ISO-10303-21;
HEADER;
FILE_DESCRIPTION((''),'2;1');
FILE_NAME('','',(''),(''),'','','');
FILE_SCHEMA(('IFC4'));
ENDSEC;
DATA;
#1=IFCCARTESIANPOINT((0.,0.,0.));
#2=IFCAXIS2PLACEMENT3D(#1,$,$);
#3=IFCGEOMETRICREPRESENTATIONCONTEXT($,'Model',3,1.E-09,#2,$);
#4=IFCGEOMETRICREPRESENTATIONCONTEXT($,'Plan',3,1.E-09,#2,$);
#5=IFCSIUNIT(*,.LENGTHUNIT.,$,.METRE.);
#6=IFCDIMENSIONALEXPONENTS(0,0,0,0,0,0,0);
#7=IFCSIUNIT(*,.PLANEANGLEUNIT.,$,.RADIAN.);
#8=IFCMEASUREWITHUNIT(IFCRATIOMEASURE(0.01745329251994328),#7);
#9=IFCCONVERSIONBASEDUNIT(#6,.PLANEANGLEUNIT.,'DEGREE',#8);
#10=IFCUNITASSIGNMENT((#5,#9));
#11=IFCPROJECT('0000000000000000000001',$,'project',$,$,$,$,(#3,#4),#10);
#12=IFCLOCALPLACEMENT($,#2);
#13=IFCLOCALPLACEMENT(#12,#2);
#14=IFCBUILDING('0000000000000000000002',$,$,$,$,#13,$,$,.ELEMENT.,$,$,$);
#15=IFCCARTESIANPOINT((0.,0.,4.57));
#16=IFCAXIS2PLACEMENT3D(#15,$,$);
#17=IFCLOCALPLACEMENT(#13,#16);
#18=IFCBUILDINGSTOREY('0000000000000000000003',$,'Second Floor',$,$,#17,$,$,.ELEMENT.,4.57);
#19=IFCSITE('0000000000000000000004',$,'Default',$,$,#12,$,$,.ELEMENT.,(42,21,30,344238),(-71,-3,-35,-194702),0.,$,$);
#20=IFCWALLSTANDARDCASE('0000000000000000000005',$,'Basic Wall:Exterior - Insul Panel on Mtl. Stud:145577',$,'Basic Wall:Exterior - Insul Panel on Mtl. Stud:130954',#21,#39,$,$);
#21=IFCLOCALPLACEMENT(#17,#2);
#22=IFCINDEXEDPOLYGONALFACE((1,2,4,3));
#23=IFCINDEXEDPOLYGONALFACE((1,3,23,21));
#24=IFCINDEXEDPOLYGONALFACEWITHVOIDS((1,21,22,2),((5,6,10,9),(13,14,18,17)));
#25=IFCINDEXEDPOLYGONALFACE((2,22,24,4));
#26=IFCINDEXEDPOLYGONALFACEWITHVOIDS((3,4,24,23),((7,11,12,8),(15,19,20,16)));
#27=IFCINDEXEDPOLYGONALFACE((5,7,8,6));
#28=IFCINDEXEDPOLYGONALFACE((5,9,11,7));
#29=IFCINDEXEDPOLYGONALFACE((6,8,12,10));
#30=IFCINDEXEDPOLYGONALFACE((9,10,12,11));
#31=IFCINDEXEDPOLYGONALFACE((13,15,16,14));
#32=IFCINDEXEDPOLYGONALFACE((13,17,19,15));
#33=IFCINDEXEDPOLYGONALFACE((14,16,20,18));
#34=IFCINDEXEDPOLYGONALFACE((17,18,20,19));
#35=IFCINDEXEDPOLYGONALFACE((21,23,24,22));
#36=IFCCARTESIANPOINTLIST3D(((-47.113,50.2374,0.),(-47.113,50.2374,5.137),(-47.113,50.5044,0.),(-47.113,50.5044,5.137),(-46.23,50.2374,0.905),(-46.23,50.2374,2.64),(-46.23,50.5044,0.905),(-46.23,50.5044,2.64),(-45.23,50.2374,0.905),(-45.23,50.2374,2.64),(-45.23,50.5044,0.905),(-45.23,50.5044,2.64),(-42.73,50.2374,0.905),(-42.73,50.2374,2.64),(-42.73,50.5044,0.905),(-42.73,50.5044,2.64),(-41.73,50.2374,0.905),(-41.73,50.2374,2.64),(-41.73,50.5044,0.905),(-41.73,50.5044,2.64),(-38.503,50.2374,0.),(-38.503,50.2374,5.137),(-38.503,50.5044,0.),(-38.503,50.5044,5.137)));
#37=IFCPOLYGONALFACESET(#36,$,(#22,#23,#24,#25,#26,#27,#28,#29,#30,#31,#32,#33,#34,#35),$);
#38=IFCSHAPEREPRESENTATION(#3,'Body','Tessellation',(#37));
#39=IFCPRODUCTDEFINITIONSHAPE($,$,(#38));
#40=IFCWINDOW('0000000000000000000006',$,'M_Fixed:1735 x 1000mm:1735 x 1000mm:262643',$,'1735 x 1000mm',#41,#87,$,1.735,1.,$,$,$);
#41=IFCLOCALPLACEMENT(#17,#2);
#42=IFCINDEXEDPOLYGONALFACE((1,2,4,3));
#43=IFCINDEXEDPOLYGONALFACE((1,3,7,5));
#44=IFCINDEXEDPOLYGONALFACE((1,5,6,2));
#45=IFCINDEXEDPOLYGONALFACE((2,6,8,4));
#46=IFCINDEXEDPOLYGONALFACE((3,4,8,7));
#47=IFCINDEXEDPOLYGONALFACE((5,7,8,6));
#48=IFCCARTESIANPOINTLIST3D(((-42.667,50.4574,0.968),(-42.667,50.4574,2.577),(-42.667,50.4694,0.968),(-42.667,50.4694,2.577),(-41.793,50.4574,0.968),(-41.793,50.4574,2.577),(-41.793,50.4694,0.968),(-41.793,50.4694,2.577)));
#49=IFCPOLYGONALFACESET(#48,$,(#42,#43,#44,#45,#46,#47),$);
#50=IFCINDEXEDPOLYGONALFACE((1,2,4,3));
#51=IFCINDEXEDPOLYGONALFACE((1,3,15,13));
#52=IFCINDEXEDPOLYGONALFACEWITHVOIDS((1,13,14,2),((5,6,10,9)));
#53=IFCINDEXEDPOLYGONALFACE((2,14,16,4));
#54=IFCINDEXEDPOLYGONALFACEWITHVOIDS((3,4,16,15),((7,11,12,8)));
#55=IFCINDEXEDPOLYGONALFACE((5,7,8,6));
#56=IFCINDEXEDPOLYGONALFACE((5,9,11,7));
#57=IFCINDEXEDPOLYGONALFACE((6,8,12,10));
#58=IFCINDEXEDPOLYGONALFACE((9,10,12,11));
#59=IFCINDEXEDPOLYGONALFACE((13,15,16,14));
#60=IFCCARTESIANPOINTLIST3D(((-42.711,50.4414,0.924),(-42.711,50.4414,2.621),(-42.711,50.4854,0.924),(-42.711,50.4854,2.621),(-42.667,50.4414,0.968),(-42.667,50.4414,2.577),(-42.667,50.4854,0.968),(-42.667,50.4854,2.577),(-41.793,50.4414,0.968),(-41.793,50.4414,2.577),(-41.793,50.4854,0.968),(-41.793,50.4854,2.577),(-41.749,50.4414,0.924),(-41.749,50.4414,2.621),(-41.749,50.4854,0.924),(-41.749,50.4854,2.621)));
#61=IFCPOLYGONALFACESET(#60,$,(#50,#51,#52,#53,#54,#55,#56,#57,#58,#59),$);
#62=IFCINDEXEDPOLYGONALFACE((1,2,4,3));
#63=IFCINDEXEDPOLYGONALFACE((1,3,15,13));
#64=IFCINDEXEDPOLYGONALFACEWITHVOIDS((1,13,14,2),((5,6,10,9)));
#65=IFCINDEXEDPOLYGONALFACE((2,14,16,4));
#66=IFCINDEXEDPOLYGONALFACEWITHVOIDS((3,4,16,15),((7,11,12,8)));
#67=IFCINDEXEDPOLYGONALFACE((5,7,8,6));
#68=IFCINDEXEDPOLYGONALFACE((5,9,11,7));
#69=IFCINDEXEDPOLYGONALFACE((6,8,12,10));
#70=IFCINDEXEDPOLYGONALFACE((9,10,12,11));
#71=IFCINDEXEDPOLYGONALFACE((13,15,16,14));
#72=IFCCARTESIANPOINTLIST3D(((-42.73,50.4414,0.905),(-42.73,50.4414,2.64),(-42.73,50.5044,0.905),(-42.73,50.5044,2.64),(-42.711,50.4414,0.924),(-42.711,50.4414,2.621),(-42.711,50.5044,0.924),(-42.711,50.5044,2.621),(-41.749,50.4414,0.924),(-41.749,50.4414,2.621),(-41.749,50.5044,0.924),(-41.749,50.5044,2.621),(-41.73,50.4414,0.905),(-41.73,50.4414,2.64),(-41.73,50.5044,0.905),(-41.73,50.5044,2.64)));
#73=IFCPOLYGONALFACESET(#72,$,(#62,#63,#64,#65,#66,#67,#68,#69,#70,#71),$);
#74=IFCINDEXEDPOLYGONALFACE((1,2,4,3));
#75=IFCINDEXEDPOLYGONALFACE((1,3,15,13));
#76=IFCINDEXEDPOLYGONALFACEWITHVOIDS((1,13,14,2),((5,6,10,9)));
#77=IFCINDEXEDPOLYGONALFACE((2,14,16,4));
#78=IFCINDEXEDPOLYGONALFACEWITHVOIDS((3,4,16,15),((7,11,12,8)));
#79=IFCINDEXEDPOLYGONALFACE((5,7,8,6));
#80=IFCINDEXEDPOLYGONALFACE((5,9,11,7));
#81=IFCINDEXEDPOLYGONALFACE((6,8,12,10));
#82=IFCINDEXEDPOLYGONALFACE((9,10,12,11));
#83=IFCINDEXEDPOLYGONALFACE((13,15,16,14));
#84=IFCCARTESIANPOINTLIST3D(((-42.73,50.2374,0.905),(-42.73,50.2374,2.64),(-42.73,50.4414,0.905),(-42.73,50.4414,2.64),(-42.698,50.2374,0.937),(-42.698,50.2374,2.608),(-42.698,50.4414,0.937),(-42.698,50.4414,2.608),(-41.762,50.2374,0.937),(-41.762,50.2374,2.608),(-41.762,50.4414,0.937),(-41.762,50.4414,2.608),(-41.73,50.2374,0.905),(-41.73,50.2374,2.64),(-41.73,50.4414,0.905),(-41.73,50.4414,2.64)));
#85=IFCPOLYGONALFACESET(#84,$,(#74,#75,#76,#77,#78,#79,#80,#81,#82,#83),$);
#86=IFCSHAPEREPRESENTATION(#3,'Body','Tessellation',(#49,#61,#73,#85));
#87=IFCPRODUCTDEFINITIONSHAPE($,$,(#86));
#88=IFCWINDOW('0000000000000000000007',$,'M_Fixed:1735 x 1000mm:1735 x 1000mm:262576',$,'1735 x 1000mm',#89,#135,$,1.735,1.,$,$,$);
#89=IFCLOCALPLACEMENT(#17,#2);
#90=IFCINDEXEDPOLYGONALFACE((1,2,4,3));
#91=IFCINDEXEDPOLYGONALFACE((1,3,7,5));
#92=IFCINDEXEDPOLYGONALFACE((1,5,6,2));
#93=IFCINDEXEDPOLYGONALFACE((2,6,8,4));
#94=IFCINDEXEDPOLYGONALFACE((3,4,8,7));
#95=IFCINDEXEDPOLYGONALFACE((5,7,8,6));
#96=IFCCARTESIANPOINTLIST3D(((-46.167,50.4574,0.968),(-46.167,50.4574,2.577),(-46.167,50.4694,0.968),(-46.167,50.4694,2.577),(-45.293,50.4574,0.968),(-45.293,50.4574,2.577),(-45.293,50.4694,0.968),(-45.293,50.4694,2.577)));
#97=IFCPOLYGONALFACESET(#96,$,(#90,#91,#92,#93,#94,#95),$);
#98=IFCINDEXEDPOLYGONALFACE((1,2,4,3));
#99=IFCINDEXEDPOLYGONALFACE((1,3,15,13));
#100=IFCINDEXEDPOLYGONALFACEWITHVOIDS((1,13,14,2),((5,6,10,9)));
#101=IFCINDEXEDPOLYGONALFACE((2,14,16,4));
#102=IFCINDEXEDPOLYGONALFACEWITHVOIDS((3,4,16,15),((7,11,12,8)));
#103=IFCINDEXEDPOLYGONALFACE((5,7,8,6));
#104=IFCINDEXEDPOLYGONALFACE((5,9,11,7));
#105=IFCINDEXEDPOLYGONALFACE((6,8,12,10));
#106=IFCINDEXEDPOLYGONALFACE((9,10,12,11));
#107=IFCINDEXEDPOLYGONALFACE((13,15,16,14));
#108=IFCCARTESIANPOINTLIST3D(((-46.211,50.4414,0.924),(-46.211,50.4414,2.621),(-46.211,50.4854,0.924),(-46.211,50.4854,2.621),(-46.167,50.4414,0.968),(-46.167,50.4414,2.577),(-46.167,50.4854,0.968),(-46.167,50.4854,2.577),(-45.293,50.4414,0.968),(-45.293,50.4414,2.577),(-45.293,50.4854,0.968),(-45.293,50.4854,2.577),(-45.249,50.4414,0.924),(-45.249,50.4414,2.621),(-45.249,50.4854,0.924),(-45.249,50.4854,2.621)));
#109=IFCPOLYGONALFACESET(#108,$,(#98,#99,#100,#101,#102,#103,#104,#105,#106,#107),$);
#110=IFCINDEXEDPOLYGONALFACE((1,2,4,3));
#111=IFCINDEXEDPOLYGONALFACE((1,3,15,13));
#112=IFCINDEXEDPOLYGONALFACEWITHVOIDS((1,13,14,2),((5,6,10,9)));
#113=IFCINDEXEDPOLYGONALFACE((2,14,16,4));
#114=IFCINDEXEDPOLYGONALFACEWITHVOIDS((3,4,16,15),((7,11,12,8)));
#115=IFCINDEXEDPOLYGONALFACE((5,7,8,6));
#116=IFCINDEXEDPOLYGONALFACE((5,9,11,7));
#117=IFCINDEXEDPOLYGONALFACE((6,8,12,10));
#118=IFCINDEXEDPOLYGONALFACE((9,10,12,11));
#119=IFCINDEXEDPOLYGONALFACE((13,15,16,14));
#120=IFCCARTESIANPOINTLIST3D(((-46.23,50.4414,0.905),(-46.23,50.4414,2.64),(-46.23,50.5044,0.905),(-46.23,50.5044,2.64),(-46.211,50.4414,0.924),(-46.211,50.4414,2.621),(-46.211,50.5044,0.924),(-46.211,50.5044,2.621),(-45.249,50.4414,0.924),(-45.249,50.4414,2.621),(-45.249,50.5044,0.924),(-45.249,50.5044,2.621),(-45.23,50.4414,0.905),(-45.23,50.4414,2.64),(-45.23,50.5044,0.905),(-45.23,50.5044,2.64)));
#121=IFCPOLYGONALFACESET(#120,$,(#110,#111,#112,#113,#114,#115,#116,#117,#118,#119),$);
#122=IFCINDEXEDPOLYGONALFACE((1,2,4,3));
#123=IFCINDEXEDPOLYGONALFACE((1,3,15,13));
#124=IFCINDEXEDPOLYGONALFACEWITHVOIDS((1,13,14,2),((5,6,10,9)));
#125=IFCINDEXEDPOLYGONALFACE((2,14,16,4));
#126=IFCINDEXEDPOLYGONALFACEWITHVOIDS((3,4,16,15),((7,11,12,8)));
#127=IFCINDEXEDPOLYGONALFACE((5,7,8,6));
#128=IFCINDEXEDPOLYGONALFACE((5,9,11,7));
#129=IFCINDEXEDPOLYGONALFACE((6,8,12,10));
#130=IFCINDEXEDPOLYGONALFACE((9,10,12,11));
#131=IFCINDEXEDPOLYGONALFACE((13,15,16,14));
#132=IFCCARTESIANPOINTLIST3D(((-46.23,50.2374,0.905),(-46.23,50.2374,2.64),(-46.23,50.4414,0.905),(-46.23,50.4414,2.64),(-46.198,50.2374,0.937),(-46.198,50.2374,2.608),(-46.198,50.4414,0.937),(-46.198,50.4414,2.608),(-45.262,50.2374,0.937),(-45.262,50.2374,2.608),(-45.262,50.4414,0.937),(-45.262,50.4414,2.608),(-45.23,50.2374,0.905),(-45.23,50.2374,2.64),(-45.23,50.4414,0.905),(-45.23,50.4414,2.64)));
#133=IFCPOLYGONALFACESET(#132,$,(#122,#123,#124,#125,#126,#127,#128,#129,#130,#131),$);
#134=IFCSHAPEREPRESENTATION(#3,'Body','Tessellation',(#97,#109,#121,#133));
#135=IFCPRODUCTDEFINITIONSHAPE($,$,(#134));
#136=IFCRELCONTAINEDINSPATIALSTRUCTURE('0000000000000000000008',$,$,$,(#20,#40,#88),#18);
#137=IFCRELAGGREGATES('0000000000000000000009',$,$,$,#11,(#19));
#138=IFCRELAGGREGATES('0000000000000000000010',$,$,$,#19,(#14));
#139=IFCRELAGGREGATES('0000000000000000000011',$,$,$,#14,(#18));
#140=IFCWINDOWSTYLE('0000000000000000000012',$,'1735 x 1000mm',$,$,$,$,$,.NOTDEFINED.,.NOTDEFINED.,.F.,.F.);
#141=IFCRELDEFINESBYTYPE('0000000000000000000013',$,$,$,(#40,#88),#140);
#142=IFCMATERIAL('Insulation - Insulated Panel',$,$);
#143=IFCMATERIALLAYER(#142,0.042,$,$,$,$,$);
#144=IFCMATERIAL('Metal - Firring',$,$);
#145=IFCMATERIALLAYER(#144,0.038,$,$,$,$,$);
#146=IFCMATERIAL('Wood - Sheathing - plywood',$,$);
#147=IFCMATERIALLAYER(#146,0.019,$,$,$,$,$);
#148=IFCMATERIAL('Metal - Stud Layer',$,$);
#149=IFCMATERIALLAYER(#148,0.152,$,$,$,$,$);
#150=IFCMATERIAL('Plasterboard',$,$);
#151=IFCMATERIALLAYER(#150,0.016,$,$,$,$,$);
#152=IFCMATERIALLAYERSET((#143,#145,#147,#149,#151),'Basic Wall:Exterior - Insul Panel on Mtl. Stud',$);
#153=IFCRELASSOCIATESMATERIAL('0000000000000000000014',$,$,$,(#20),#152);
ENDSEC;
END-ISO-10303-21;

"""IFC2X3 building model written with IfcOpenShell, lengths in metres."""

from ifc_helpers import new_model, entity, si_unit, converted_unit, frame, frame_2d, origin, origin_2d_with_axis, place, context, project, spatial, polyline, rectangle, outline, extrude, source, transform, mapped, material, layer, layer_set, layer_usage, type_object, type_shapes, element, fill, save


model = new_model("IFC2X3")

# Units and contexts
model_context = context("Model", 3, precision=1e-09, world=origin())
plan_context = context("Plan", 3, precision=1e-09, world=origin())
ifc_project = project(units=[si_unit("LENGTHUNIT", "METRE"), converted_unit("PLANEANGLEUNIT", "DEGREE", entity("IfcRatioMeasure", 0.01745329251994328), si_unit("PLANEANGLEUNIT", "RADIAN"), dimensions=[0, 0, 0, 0, 0, 0, 0])], contexts=[model_context, plan_context])

# Site, building, storey
site_placement = place(None, origin())
site = spatial("IfcSite", under=ifc_project, at=site_placement, Name="Default", CompositionType="ELEMENT", RefLatitude=(42, 21, 30, 344238), RefLongitude=(-71, -3, -35, -194702), RefElevation=0.0)
building_placement = place(site_placement, origin())
building = spatial("IfcBuilding", under=site, at=building_placement, CompositionType="ELEMENT")
storey_placement = place(building_placement, frame((0.0, 0.0, 4.57)))
storey = spatial("IfcBuildingStorey", under=building, at=storey_placement, Name="Second Floor", CompositionType="ELEMENT", Elevation=4.57)

# Shared definitions
ifc_material_1 = material(Name="Plasterboard")
ifc_material_2 = material(Name="Metal - Stud Layer")

# Wall, openings, windows
ifc_material_3 = material(Name="Insulation - Insulated Panel")
ifc_layer_1 = layer(ifc_material_3, 0.042)
ifc_material_4 = material(Name="Metal - Firring")
ifc_layer_2 = layer(ifc_material_4, 0.038)
ifc_material_5 = material(Name="Wood - Sheathing - plywood")
ifc_layer_3 = layer(ifc_material_5, 0.019)
ifc_layer_4 = layer(ifc_material_2, 0.152)
ifc_layer_5 = layer(ifc_material_1, 0.016)
ifc_layer_set_1 = layer_set([ifc_layer_1, ifc_layer_2, ifc_layer_3, ifc_layer_4, ifc_layer_5], Name="Basic Wall:Exterior - Insul Panel on Mtl. Stud")
ifc_layer_usage_1 = layer_usage(ifc_layer_set_1, "AXIS2", "NEGATIVE", 0.1335)
wall_1_placement = place(storey_placement, frame((-47.113, 50.3709, 0.0)))
wall_1 = element("IfcWallStandardCase", 1, at=wall_1_placement, inside=storey, material=ifc_layer_usage_1, Name="Basic Wall:Exterior - Insul Panel on Mtl. Stud:145577", ObjectType="Basic Wall:Exterior - Insul Panel on Mtl. Stud:130954", context=model_context, shape_type="SweptSolid", body=[
    extrude(rectangle(XDim=8.61, YDim=0.267, at=frame_2d((4.305, 0.0), x_axis=(-1.0, 0.0))), origin(), (0.0, 0.0, 1.0), 5.137),
])
opening_1_placement = place(wall_1_placement, frame((4.383, -0.1335, 0.905)))
opening_1 = element("IfcOpeningElement", 2, at=opening_1_placement, cuts=wall_1, ObjectType="Opening", context=model_context, shape_type="SweptSolid", body=[
    extrude(rectangle(XDim=1.735, YDim=1.0, at=frame_2d((0.8675, 0.5), x_axis=(1.0, 0.0))), frame((0.0, 0.0, 0.0), z_axis=(0.0, 1.0, 0.0), x_axis=(0.0, 0.0, 1.0)), (0.0, 0.0, 1.0), 0.267),
])
opening_2_placement = place(wall_1_placement, frame((0.883, -0.1335, 0.905)))
opening_2 = element("IfcOpeningElement", 3, at=opening_2_placement, cuts=wall_1, ObjectType="Opening", context=model_context, shape_type="SweptSolid", body=[
    extrude(rectangle(XDim=1.735, YDim=1.0, at=frame_2d((0.8675, 0.5), x_axis=(1.0, 0.0))), frame((0.0, 0.0, 0.0), z_axis=(0.0, 1.0, 0.0), x_axis=(0.0, 0.0, 1.0)), (0.0, 0.0, 1.0), 0.267),
])
window_style = type_object("IfcWindowStyle", Name="1735 x 1000mm", ConstructionType="NOTDEFINED", OperationType="NOTDEFINED", ParameterTakesPrecedence=False, Sizeable=False)
shared_shape_1 = source(origin(), model_context, "Body", "SweptSolid", [
    extrude(rectangle(XDim=0.012, YDim=0.874, at=origin_2d_with_axis()), frame((0.5, 0.226, 0.063), z_axis=(0.0, 0.0, 1.0), x_axis=(0.0, -1.0, 0.0)), (0.0, 0.0, 1.0), 1.609),
    extrude(outline(polyline([(-0.481, -0.8485), (0.481, -0.8485), (0.481, 0.8485), (-0.481, 0.8485), (-0.481, -0.8485)]), holes=[polyline([(-0.437, -0.8045), (-0.437, 0.8045), (0.437, 0.8045), (0.437, -0.8045), (-0.437, -0.8045)])]), frame((0.5, 0.204, 0.8675), z_axis=(0.0, 1.0, 0.0), x_axis=(1.0, 0.0, 0.0)), (0.0, 0.0, 1.0), 0.044),
    extrude(outline(polyline([(-0.5, -0.8675), (0.5, -0.8675), (0.5, 0.8675), (-0.5, 0.8675), (-0.5, -0.8675)]), holes=[polyline([(-0.481, -0.8485), (-0.481, 0.8485), (0.481, 0.8485), (0.481, -0.8485), (-0.481, -0.8485)])]), frame((0.5, 0.204, 0.8675), z_axis=(0.0, 1.0, 0.0), x_axis=(1.0, 0.0, 0.0)), (0.0, 0.0, 1.0), 0.063),
    extrude(outline(polyline([(-0.5, -0.8675), (0.5, -0.8675), (0.5, 0.8675), (-0.5, 0.8675), (-0.5, -0.8675)]), holes=[polyline([(-0.468, -0.8355), (-0.468, 0.8355), (0.468, 0.8355), (0.468, -0.8355), (-0.468, -0.8355)])]), frame((0.5, 0.0, 0.8675), z_axis=(0.0, 1.0, 0.0), x_axis=(1.0, 0.0, 0.0)), (0.0, 0.0, 1.0), 0.204),
])
type_shapes(window_style, [shared_shape_1])
window_1_placement = place(opening_1_placement, origin())
window_1 = element("IfcWindow", 4, at=window_1_placement, inside=storey, type_object=window_style, Name="M_Fixed:1735 x 1000mm:1735 x 1000mm:262643", ObjectType="1735 x 1000mm", OverallHeight=1.735, OverallWidth=1.0, context=model_context, shape_type="MappedRepresentation", body=[
    mapped(shared_shape_1, transform((0.0, 0.0, 0.0), scale=1.0)),
])
fill(opening_1, window_1)
window_2_placement = place(opening_2_placement, origin())
window_2 = element("IfcWindow", 5, at=window_2_placement, inside=storey, type_object=window_style, Name="M_Fixed:1735 x 1000mm:1735 x 1000mm:262576", ObjectType="1735 x 1000mm", OverallHeight=1.735, OverallWidth=1.0, context=model_context, shape_type="MappedRepresentation", body=[
    mapped(shared_shape_1, transform((0.0, 0.0, 0.0), scale=1.0)),
])
fill(opening_2, window_2)

save(model, "model.ifc")
